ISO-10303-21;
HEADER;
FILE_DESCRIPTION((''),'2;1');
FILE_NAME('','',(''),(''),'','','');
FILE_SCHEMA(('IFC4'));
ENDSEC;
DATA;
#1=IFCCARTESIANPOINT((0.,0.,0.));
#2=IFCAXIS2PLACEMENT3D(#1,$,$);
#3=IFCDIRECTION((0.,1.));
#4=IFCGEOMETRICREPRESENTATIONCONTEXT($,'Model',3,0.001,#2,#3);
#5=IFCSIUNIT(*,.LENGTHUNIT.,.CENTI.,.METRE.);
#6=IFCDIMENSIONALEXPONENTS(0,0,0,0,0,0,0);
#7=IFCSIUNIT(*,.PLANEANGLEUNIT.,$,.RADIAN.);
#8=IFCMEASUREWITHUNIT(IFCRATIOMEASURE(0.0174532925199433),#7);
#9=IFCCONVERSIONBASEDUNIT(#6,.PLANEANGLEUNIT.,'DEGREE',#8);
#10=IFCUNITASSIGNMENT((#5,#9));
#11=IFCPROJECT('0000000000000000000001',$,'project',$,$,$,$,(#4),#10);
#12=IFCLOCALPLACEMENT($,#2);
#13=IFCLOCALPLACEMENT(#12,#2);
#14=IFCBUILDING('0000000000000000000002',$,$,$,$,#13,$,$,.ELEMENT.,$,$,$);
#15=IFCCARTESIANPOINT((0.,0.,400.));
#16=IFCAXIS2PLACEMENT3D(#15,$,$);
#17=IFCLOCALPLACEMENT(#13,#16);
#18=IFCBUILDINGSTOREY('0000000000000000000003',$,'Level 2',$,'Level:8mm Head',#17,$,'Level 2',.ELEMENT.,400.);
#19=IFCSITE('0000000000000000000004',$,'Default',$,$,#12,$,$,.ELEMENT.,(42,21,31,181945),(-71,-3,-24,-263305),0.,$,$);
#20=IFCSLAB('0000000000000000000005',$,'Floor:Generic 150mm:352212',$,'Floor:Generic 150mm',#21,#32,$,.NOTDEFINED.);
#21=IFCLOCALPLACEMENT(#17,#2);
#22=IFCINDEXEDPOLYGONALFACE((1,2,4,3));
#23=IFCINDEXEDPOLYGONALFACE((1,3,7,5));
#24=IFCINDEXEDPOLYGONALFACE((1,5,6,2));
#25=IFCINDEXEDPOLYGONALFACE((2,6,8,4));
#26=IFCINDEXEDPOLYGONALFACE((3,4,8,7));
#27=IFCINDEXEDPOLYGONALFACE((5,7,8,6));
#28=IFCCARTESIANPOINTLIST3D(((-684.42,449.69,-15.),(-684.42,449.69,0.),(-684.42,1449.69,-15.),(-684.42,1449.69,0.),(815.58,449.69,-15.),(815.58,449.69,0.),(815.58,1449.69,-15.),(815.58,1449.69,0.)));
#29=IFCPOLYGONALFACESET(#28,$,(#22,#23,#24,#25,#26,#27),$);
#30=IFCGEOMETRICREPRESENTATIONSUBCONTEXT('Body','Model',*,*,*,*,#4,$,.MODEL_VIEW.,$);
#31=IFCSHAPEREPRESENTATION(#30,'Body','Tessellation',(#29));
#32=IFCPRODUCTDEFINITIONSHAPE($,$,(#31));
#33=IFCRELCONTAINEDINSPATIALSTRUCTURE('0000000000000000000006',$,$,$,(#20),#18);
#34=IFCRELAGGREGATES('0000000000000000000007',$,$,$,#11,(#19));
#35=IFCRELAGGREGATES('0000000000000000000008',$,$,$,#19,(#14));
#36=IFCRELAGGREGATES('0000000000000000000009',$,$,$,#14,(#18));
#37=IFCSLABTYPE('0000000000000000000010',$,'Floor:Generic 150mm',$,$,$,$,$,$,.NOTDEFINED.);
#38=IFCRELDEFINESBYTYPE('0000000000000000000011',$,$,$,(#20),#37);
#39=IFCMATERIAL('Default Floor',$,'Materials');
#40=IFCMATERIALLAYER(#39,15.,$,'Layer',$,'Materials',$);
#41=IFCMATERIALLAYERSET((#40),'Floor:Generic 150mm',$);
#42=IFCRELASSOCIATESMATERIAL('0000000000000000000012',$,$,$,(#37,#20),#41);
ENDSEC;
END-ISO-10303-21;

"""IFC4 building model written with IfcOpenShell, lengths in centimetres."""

from ifc_helpers import new_model, entity, si_unit, converted_unit, direction, frame, origin, origin_2d_with_axis, place, context, subcontext, project, spatial, rectangle, extrude, material, layer, layer_set, layer_usage, type_object, element, save


model = new_model("IFC4")

# Units and contexts
model_context = context("Model", 3, precision=0.001, world=origin(), true_north=direction((0.0, 1.0)))
body_context = subcontext(model_context, "Body", "Model", "MODEL_VIEW")
ifc_project = project(units=[si_unit("LENGTHUNIT", "METRE", prefix="CENTI"), converted_unit("PLANEANGLEUNIT", "DEGREE", entity("IfcRatioMeasure", 0.0174532925199433), si_unit("PLANEANGLEUNIT", "RADIAN"), dimensions=[0, 0, 0, 0, 0, 0, 0])], contexts=[model_context])

# Site, building, storey
site_placement = place(None, origin())
site = spatial("IfcSite", under=ifc_project, at=site_placement, Name="Default", CompositionType="ELEMENT", RefLatitude=(42, 21, 31, 181945), RefLongitude=(-71, -3, -24, -263305), RefElevation=0.0)
building_placement = place(site_placement, origin())
building = spatial("IfcBuilding", under=site, at=building_placement, CompositionType="ELEMENT")
storey_placement = place(building_placement, frame((0.0, 0.0, 400.0)))
storey = spatial("IfcBuildingStorey", under=building, at=storey_placement, Name="Level 2", ObjectType="Level:8mm Head", LongName="Level 2", CompositionType="ELEMENT", Elevation=400.0)

# Slab
ifc_material = material(Name="Default Floor", Category="Materials")
ifc_layer = layer(ifc_material, 15.0, Name="Layer", Category="Materials")
ifc_layer_set = layer_set([ifc_layer], Name="Floor:Generic 150mm")
ifc_layer_usage = layer_usage(ifc_layer_set, "AXIS3", "POSITIVE", 0.0)
slab_type = type_object("IfcSlabType", Name="Floor:Generic 150mm", PredefinedType="NOTDEFINED", material=ifc_layer_set)
slab_placement = place(storey_placement, origin())
element("IfcSlab", 1, at=slab_placement, inside=storey, type_object=slab_type, material=ifc_layer_usage, Name="Floor:Generic 150mm:352212", ObjectType="Floor:Generic 150mm", PredefinedType="NOTDEFINED", context=body_context, shape_type="SweptSolid", body=[
    extrude(rectangle(XDim=1000.0, YDim=1500.0, at=origin_2d_with_axis()), frame((65.58, 949.69, 0.0), z_axis=(0.0, 0.0, -1.0), x_axis=(0.0, 1.0, 0.0)), (0.0, 0.0, 1.0), 15.0),
])

save(model, "model.ifc")
